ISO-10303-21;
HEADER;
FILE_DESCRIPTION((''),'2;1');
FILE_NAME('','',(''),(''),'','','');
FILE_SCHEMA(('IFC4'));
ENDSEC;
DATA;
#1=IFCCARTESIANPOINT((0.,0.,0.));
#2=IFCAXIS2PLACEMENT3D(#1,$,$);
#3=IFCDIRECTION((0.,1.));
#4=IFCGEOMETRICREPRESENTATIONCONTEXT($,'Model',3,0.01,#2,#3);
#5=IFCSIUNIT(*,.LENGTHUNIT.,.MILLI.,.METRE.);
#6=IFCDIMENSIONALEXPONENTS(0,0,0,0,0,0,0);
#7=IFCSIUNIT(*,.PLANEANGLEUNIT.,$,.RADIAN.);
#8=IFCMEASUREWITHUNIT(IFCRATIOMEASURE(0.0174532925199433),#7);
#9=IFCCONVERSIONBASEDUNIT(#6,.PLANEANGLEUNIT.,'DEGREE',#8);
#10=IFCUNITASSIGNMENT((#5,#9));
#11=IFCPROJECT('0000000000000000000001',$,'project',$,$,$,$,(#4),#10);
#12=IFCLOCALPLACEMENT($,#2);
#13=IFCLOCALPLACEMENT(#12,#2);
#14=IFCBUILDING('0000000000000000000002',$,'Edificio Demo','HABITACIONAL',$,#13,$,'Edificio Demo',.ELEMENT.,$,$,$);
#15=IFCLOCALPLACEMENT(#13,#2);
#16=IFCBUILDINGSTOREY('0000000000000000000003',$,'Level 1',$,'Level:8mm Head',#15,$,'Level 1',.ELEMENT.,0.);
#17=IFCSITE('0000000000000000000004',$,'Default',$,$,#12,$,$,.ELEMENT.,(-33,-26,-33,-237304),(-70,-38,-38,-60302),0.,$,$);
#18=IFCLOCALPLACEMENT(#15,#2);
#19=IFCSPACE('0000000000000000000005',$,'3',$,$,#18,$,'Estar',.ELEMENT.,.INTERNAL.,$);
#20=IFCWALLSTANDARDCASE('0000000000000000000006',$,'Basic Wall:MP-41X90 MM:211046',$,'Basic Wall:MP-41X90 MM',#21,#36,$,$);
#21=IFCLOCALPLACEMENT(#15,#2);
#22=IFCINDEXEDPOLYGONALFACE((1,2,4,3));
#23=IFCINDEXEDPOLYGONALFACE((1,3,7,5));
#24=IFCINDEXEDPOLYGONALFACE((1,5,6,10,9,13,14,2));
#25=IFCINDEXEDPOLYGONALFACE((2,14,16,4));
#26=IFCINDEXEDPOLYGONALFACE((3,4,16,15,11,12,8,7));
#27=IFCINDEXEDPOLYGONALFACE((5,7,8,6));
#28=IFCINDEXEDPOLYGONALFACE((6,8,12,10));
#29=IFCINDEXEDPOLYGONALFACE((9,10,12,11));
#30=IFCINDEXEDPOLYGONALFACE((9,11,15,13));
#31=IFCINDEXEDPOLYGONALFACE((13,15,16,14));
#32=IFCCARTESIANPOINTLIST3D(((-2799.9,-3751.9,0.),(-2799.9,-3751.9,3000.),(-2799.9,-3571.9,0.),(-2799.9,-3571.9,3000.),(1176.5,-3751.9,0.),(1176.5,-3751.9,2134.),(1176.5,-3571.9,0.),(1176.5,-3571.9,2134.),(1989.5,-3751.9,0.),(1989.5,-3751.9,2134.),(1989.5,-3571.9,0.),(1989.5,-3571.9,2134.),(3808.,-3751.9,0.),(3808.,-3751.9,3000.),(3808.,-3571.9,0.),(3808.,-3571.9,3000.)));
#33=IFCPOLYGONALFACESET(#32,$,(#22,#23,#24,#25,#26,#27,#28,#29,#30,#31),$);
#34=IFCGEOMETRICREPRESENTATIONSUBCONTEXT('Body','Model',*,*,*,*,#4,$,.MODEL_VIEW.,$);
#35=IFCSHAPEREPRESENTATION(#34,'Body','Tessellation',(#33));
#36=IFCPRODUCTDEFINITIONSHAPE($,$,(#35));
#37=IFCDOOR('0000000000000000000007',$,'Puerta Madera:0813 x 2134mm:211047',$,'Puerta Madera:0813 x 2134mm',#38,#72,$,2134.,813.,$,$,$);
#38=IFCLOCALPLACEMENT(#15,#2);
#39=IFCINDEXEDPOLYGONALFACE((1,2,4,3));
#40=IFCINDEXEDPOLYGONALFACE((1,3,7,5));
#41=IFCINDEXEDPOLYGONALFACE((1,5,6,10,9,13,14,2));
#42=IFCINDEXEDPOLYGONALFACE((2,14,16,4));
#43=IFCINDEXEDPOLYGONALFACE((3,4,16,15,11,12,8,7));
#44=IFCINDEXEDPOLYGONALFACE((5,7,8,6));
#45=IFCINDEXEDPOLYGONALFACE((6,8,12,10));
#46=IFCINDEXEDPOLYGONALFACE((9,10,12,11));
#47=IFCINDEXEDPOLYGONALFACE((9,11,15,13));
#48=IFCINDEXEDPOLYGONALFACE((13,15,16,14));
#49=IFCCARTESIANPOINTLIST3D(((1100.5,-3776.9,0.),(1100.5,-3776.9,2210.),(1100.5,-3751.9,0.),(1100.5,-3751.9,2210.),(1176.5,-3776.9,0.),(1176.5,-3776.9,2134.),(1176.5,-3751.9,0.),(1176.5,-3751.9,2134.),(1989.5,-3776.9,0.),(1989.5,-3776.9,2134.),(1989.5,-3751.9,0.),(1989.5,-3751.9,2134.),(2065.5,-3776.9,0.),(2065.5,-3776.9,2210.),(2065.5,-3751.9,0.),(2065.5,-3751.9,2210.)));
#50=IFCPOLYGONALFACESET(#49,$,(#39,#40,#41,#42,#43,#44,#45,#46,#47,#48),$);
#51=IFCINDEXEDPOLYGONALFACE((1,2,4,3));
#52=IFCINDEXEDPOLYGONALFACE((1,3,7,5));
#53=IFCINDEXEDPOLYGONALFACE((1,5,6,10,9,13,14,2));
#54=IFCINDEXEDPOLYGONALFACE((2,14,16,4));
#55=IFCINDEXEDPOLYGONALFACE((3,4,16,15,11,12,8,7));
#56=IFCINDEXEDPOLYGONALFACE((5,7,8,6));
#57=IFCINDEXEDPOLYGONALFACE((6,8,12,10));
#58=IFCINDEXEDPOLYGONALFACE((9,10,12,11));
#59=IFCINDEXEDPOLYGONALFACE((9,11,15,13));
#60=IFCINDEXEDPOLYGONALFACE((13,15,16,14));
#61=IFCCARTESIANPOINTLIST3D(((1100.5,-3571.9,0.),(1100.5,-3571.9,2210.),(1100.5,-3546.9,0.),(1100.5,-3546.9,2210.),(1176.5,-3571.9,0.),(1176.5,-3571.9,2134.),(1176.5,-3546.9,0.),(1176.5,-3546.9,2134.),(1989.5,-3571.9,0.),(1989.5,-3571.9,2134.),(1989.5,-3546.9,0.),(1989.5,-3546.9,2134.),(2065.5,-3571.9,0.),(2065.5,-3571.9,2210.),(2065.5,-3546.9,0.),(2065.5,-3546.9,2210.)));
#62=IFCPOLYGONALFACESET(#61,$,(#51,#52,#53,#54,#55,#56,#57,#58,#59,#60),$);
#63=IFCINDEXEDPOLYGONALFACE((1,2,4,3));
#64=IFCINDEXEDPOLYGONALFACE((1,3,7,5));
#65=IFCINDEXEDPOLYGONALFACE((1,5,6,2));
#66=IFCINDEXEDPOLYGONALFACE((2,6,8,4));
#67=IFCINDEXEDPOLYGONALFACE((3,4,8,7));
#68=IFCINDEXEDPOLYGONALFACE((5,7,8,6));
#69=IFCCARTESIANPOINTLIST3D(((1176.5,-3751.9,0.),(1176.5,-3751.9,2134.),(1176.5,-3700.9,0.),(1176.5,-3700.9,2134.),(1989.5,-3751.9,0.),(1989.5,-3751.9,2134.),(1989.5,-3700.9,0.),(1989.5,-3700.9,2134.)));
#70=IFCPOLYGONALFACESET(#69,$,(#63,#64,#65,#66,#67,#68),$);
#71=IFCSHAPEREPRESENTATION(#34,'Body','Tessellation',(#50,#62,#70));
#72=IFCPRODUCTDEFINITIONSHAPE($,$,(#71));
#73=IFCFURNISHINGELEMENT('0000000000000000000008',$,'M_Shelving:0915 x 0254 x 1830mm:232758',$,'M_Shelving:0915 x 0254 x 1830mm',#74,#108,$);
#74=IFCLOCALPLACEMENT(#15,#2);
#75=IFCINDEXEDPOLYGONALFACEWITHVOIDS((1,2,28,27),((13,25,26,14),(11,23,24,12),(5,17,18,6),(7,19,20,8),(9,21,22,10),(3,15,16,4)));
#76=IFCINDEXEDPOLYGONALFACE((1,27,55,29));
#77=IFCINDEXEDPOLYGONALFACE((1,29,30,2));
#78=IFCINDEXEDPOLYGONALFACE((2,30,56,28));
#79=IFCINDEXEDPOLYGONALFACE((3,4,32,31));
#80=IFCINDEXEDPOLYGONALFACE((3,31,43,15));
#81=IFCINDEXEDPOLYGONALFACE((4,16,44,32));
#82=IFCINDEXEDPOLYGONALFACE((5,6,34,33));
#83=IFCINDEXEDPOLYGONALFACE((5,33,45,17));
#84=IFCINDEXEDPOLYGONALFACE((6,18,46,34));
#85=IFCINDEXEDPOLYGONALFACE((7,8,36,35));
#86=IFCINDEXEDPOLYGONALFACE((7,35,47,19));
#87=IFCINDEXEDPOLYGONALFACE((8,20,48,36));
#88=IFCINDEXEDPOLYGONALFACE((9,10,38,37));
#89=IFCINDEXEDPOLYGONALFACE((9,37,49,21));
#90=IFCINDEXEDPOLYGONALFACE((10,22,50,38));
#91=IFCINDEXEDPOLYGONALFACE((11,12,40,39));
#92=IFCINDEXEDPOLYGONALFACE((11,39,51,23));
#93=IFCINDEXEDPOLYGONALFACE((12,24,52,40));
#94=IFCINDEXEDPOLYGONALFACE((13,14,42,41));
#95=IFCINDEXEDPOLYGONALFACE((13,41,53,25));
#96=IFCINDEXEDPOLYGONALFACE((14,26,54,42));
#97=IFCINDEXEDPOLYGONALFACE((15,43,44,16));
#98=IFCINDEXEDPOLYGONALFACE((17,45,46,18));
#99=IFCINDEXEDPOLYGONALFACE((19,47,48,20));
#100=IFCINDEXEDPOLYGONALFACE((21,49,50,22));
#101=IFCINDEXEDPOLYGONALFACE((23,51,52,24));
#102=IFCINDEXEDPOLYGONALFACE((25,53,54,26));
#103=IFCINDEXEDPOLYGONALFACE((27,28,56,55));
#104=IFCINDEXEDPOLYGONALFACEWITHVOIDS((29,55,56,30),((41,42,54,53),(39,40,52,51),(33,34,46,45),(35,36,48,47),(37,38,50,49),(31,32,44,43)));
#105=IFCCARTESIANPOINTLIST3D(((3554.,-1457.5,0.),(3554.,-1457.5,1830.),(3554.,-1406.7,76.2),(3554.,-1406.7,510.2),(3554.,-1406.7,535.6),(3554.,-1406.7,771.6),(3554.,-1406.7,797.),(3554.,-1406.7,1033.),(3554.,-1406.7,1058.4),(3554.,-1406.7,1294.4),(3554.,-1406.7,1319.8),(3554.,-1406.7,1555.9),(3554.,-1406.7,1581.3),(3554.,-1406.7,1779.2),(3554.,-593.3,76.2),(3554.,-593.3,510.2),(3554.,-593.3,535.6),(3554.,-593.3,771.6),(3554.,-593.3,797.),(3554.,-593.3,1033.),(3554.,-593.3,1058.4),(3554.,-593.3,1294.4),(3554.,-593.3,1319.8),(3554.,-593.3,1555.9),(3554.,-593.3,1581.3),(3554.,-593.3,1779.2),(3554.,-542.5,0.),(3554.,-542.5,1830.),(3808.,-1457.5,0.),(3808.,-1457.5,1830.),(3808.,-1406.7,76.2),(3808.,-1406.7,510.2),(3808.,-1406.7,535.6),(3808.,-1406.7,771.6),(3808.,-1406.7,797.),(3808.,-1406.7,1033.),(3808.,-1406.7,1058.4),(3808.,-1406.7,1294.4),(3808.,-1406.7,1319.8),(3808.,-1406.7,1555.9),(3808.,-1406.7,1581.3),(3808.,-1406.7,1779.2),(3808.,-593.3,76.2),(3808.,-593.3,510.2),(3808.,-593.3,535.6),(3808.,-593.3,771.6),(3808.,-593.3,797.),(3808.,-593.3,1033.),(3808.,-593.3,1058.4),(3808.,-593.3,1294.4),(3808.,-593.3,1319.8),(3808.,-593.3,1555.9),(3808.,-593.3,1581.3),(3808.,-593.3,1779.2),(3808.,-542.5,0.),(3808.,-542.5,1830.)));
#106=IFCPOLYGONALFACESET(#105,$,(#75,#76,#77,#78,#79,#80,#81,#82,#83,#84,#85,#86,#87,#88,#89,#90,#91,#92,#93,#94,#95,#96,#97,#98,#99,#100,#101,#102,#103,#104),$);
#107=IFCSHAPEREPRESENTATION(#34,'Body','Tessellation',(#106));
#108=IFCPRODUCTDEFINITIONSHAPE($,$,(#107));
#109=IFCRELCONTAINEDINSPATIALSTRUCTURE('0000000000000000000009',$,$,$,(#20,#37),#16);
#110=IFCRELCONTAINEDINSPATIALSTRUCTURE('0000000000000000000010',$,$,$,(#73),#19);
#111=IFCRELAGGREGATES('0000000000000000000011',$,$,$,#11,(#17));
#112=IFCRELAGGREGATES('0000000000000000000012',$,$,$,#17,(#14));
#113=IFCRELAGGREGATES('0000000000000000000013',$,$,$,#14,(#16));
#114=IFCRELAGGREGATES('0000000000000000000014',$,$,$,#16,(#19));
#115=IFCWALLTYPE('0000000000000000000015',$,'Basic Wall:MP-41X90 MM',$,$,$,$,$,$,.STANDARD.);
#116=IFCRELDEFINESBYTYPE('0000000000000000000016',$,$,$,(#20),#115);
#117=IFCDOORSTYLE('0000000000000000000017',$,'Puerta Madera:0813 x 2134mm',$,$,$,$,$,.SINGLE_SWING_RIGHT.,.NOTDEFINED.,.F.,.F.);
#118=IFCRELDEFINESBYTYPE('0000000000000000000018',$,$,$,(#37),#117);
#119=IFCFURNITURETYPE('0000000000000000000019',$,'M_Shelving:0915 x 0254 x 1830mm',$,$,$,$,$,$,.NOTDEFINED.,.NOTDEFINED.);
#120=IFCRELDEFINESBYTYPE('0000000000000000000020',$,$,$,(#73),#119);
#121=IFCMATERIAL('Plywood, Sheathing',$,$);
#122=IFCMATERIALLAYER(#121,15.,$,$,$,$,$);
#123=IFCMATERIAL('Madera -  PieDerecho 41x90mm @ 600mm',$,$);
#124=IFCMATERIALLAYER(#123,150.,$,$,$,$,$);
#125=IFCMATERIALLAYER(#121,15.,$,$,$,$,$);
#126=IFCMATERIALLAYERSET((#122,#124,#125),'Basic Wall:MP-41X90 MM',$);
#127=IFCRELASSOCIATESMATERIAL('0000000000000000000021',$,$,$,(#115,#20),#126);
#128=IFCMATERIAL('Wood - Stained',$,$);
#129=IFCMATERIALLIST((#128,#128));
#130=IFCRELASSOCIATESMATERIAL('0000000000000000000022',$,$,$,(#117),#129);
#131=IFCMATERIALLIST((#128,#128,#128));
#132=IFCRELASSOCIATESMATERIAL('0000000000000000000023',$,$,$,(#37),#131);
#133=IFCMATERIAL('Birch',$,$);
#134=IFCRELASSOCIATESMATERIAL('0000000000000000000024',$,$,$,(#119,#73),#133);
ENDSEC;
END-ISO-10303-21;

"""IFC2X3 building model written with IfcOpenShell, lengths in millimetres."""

from ifc_helpers import new_model, entity, si_unit, converted_unit, direction, frame, frame_2d, origin, place, context, subcontext, project, spatial, polyline, rectangle, outline, extrude, source, transform, mapped, material, material_list, layer, layer_set, layer_usage, type_object, type_shapes, element, fill, save


model = new_model("IFC2X3")

# Units and contexts
model_context = context("Model", 3, precision=0.01, world=origin(), true_north=direction((0.0, 1.0)))
body_context = subcontext(model_context, "Body", "Model", "MODEL_VIEW")
ifc_project = project(units=[si_unit("LENGTHUNIT", "METRE", prefix="MILLI"), converted_unit("PLANEANGLEUNIT", "DEGREE", entity("IfcRatioMeasure", 0.0174532925199433), si_unit("PLANEANGLEUNIT", "RADIAN"), dimensions=[0, 0, 0, 0, 0, 0, 0])], contexts=[model_context])

# Site, building, storey
site_placement = place(None, origin())
site = spatial("IfcSite", under=ifc_project, at=site_placement, Name="Default", CompositionType="ELEMENT", RefLatitude=(-33, -26, -33, -237304), RefLongitude=(-70, -38, -38, -60302), RefElevation=0.0)
building_placement = place(site_placement, origin())
building = spatial("IfcBuilding", under=site, at=building_placement, Name="Edificio Demo", Description="HABITACIONAL", LongName="Edificio Demo", CompositionType="ELEMENT")
storey_placement = place(building_placement, origin())
storey = spatial("IfcBuildingStorey", under=building, at=storey_placement, Name="Level 1", ObjectType="Level:8mm Head", LongName="Level 1", CompositionType="ELEMENT", Elevation=0.0)

# Shared definitions
ifc_material_1 = material(Name="Plywood, Sheathing")

# Shared definitions
ifc_material_2 = material(Name="Wood - Stained")

# Wall, opening, door
ifc_layer_1 = layer(ifc_material_1, 15.0)
ifc_material_3 = material(Name="Madera -  PieDerecho 41x90mm @ 600mm")
ifc_layer_2 = layer(ifc_material_3, 150.0)
ifc_layer_3 = layer(ifc_material_1, 15.0)
ifc_layer_set_1 = layer_set([ifc_layer_1, ifc_layer_2, ifc_layer_3], Name="Basic Wall:MP-41X90 MM")
ifc_layer_usage_1 = layer_usage(ifc_layer_set_1, "AXIS2", "NEGATIVE", 90.0)
wall_type_1 = type_object("IfcWallType", Name="Basic Wall:MP-41X90 MM", PredefinedType="STANDARD", material=ifc_layer_set_1)
wall_1_placement = place(storey_placement, frame((3808.0, -3661.9, 0.0), z_axis=(0.0, 0.0, 1.0), x_axis=(-1.0, 0.0, 0.0)))
wall_1 = element("IfcWallStandardCase", 1, at=wall_1_placement, inside=storey, type_object=wall_type_1, material=ifc_layer_usage_1, Name="Basic Wall:MP-41X90 MM:211046", ObjectType="Basic Wall:MP-41X90 MM", context=body_context, shape_type="SweptSolid", body=[
    extrude(rectangle(XDim=6607.9, YDim=180.0, at=frame_2d((3303.9, 0.0), x_axis=(-1.0, 0.0))), origin(), (0.0, 0.0, 1.0), 3000.0),
])
opening_1_placement = place(wall_1_placement, frame((1818.5, -90.0, 0.0)))
opening_1 = element("IfcOpeningElement", 2, at=opening_1_placement, cuts=wall_1, ObjectType="Opening", context=body_context, shape_type="SweptSolid", body=[
    extrude(rectangle(XDim=813.0, YDim=2134.0, at=frame_2d((1067.0, 406.5), x_axis=(0.0, 1.0))), frame((0.0, 0.0, 0.0), z_axis=(0.0, 1.0, 0.0), x_axis=(0.0, 0.0, 1.0)), (0.0, 0.0, 1.0), 180.0),
])
ifc_material_list_1 = material_list([ifc_material_2, ifc_material_2, ifc_material_2])
ifc_material_list_2 = material_list([ifc_material_2, ifc_material_2])
door_style_1 = type_object("IfcDoorStyle", Name="Puerta Madera:0813 x 2134mm", ConstructionType="NOTDEFINED", OperationType="SINGLE_SWING_RIGHT", ParameterTakesPrecedence=False, Sizeable=False, material=ifc_material_list_2)
shared_shape_1 = source(origin(), body_context, "Body", "SweptSolid", [
    extrude(outline(polyline([(-482.5, -1124.0), (482.5, -1124.0), (482.5, 1086.0), (406.5, 1086.0), (406.5, -1048.0), (-406.5, -1048.0), (-406.5, 1086.0), (-482.5, 1086.0), (-482.5, -1124.0)])), frame((406.5, 180.0, 1086.0), z_axis=(0.0, 1.0, 0.0), x_axis=(1.0, 0.0, 0.0)), (0.0, 0.0, 1.0), 25.0),
    extrude(outline(polyline([(-1124.0, -482.5), (1086.0, -482.5), (1086.0, -406.5), (-1048.0, -406.5), (-1048.0, 406.5), (1086.0, 406.5), (1086.0, 482.5), (-1124.0, 482.5), (-1124.0, -482.5)])), frame((406.5, -25.0, 1086.0), z_axis=(0.0, 1.0, 0.0), x_axis=(0.0, 0.0, -1.0)), (0.0, 0.0, 1.0), 25.0),
    extrude(rectangle(XDim=51.0, YDim=813.0, at=frame_2d((0.0, 0.0), x_axis=(1.0, 0.0))), frame((406.5, 154.5, 0.0), z_axis=(0.0, 0.0, 1.0), x_axis=(0.0, 1.0, 0.0)), (0.0, 0.0, 1.0), 2134.0),
])
type_shapes(door_style_1, [shared_shape_1])
door_1_placement = place(opening_1_placement, origin())
door_1 = element("IfcDoor", 3, at=door_1_placement, inside=storey, type_object=door_style_1, material=ifc_material_list_1, Name="Puerta Madera:0813 x 2134mm:211047", ObjectType="Puerta Madera:0813 x 2134mm", OverallHeight=2134.0, OverallWidth=813.0, context=body_context, shape_type="MappedRepresentation", body=[
    mapped(shared_shape_1, transform((0.0, 0.0, 0.0), scale=1.0)),
])
fill(opening_1, door_1)

# Shared definitions
space_1_placement = place(storey_placement, origin())
space_1 = spatial("IfcSpace", under=storey, at=space_1_placement, Name="3", LongName="Estar", CompositionType="ELEMENT", InteriorOrExteriorSpace="INTERNAL")

# Furnishing element
ifc_material_4 = material(Name="Birch")
furniture_type_1 = type_object("IfcFurnitureType", Name="M_Shelving:0915 x 0254 x 1830mm", material=ifc_material_4)
shared_shape_2 = source(origin(), body_context, "Body", "SweptSolid", [
    extrude(outline(polyline([(-457.5, -915.0), (457.5, -915.0), (457.5, 915.0), (-457.5, 915.0), (-457.5, -915.0)]), holes=[polyline([(-406.7, 864.2), (406.7, 864.2), (406.7, 666.3), (-406.7, 666.3), (-406.7, 864.2)]), polyline([(-406.7, -838.8), (-406.7, -404.8), (406.7, -404.8), (406.7, -838.8), (-406.7, -838.8)]), polyline([(406.7, 143.4), (-406.7, 143.4), (-406.7, 379.4), (406.7, 379.4), (406.7, 143.4)]), polyline([(-406.7, 640.9), (406.7, 640.9), (406.7, 404.8), (-406.7, 404.8), (-406.7, 640.9)]), polyline([(-406.7, 118.0), (406.7, 118.0), (406.7, -118.0), (-406.7, -118.0), (-406.7, 118.0)]), polyline([(-406.7, -143.4), (406.7, -143.4), (406.7, -379.4), (-406.7, -379.4), (-406.7, -143.4)])]), frame((457.5, 0.0, 915.0), z_axis=(0.0, 1.0, 0.0), x_axis=(-1.0, 0.0, 0.0)), (0.0, 0.0, 1.0), 254.0),
])
type_shapes(furniture_type_1, [shared_shape_2])
furnishing_1_placement = place(space_1_placement, frame((3808.0, -1457.5, 0.0), z_axis=(0.0, 0.0, 1.0), x_axis=(0.0, 1.0, 0.0)))
element("IfcFurnishingElement", 4, at=furnishing_1_placement, inside=space_1, type_object=furniture_type_1, material=ifc_material_4, Name="M_Shelving:0915 x 0254 x 1830mm:232758", ObjectType="M_Shelving:0915 x 0254 x 1830mm", context=body_context, shape_type="MappedRepresentation", body=[
    mapped(shared_shape_2, transform((0.0, 0.0, 0.0), scale=1.0)),
])

save(model, "model.ifc")
